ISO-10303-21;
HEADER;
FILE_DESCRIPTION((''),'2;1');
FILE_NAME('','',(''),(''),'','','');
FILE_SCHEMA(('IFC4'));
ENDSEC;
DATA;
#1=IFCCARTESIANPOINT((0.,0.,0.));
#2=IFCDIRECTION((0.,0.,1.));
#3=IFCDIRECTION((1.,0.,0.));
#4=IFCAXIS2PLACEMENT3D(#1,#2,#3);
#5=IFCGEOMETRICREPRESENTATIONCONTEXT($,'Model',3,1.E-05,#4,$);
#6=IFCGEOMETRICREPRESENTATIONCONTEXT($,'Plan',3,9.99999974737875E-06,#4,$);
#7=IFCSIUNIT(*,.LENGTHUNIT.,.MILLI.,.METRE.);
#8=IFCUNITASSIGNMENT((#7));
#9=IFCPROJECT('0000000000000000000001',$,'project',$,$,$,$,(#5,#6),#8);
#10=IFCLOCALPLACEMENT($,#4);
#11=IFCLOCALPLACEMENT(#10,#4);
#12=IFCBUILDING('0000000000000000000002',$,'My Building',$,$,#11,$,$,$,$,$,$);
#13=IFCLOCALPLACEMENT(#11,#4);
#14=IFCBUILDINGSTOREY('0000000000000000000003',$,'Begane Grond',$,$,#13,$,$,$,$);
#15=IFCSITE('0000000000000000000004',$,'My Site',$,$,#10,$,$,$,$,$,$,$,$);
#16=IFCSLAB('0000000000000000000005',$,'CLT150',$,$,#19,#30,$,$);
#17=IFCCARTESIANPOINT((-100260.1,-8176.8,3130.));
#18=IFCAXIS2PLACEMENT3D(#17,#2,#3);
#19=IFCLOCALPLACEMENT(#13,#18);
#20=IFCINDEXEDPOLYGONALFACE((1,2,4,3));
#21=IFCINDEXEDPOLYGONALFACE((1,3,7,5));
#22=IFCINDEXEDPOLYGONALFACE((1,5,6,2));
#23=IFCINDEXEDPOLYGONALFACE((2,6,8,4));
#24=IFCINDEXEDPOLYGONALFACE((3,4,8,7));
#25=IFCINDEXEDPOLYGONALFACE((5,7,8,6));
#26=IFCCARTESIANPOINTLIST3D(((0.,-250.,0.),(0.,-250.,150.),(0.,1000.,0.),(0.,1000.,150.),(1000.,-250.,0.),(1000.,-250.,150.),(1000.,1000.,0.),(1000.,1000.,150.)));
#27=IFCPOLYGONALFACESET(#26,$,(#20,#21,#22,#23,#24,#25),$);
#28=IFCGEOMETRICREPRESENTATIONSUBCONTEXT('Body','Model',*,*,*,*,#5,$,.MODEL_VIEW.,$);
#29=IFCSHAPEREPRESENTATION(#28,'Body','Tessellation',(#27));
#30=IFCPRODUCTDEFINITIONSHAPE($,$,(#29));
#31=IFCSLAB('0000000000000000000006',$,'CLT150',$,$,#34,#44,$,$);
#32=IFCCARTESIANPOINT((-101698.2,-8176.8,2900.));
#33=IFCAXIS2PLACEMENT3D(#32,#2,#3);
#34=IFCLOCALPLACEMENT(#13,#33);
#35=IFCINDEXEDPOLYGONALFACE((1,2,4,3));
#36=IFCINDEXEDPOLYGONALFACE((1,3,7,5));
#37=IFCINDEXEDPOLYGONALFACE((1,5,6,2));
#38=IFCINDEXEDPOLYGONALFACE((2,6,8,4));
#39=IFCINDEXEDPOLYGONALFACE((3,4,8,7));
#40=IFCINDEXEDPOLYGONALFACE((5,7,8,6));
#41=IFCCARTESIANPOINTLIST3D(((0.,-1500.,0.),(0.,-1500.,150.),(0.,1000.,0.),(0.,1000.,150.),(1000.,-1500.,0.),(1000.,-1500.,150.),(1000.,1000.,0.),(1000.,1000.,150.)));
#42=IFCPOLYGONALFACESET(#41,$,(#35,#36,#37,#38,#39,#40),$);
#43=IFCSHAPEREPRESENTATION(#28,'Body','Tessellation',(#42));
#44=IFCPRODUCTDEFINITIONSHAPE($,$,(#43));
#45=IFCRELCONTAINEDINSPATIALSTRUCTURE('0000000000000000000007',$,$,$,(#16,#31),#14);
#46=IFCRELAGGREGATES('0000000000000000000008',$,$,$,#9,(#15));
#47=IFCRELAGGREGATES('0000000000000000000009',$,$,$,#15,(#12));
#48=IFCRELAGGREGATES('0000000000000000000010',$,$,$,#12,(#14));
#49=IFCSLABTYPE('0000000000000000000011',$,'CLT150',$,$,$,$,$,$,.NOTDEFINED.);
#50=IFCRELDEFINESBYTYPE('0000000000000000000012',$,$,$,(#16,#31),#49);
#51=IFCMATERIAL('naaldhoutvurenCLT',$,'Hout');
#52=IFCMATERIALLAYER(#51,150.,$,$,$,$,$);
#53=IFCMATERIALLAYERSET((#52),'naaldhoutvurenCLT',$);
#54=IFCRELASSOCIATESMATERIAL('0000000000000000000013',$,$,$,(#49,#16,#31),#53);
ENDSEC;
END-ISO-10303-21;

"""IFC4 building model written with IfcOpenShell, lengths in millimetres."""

from ifc_helpers import new_model, si_unit, frame, origin_with_axes, place, context, subcontext, project, spatial, line, indexed_curve, outline, extrude, material, layer, layer_set, layer_usage, type_object, element, save


model = new_model("IFC4")

# Units and contexts
model_context = context("Model", 3, precision=1e-05, world=origin_with_axes())
plan_context = context("Plan", 3, precision=9.99999974737875e-06, world=origin_with_axes())
body_context = subcontext(model_context, "Body", "Model", "MODEL_VIEW")
ifc_project = project(units=[si_unit("LENGTHUNIT", "METRE", prefix="MILLI")], contexts=[model_context, plan_context])

# Site, building, storey
site_placement = place(None, frame((0.0, 0.0, 0.0), z_axis=(0.0, 0.0, 1.0), x_axis=(1.0, 0.0, 0.0)))
site = spatial("IfcSite", under=ifc_project, at=site_placement, Name="My Site")
building_placement = place(site_placement, origin_with_axes())
building = spatial("IfcBuilding", under=site, at=building_placement, Name="My Building")
storey_placement = place(building_placement, origin_with_axes())
storey = spatial("IfcBuildingStorey", under=building, at=storey_placement, Name="Begane Grond")

# Slabs
ifc_material_1 = material(Name="naaldhoutvurenCLT", Category="Hout")
ifc_layer_1 = layer(ifc_material_1, 150.0)
ifc_layer_set_1 = layer_set([ifc_layer_1], Name="naaldhoutvurenCLT")
ifc_layer_usage_1 = layer_usage(ifc_layer_set_1, "AXIS3", "POSITIVE", 0.0)
slab_type_1 = type_object("IfcSlabType", Name="CLT150", PredefinedType="NOTDEFINED", material=ifc_layer_set_1)
slab_1_placement = place(storey_placement, frame((-100260.1, -8176.8, 3130.0), z_axis=(0.0, 0.0, 1.0), x_axis=(1.0, 0.0, 0.0)))
element("IfcSlab", 1, at=slab_1_placement, inside=storey, type_object=slab_type_1, material=ifc_layer_usage_1, Name="CLT150", context=body_context, shape_type="SweptSolid", body=[
    extrude(outline(indexed_curve([(1000.0, 1000.0), (1000.0, -250.0), (0.0, -250.0), (0.0, 1000.0)], segments=[line(4, 1), line(1, 2), line(2, 3), line(3, 4)], self_intersect=False)), None, (0.0, 0.0, 1.0), 150.0),
])
ifc_layer_usage_2 = layer_usage(ifc_layer_set_1, "AXIS3", "POSITIVE", 0.0)
slab_2_placement = place(storey_placement, frame((-101698.2, -8176.8, 2900.0), z_axis=(0.0, 0.0, 1.0), x_axis=(1.0, 0.0, 0.0)))
element("IfcSlab", 2, at=slab_2_placement, inside=storey, type_object=slab_type_1, material=ifc_layer_usage_2, Name="CLT150", context=body_context, shape_type="SweptSolid", body=[
    extrude(outline(indexed_curve([(0.0, -1500.0), (1000.0, -1500.0), (1000.0, 1000.0), (0.0, 1000.0)], segments=[line(3, 2), line(2, 1), line(1, 4), line(4, 3)], self_intersect=False)), None, (0.0, 0.0, 1.0), 150.0),
])

save(model, "model.ifc")
